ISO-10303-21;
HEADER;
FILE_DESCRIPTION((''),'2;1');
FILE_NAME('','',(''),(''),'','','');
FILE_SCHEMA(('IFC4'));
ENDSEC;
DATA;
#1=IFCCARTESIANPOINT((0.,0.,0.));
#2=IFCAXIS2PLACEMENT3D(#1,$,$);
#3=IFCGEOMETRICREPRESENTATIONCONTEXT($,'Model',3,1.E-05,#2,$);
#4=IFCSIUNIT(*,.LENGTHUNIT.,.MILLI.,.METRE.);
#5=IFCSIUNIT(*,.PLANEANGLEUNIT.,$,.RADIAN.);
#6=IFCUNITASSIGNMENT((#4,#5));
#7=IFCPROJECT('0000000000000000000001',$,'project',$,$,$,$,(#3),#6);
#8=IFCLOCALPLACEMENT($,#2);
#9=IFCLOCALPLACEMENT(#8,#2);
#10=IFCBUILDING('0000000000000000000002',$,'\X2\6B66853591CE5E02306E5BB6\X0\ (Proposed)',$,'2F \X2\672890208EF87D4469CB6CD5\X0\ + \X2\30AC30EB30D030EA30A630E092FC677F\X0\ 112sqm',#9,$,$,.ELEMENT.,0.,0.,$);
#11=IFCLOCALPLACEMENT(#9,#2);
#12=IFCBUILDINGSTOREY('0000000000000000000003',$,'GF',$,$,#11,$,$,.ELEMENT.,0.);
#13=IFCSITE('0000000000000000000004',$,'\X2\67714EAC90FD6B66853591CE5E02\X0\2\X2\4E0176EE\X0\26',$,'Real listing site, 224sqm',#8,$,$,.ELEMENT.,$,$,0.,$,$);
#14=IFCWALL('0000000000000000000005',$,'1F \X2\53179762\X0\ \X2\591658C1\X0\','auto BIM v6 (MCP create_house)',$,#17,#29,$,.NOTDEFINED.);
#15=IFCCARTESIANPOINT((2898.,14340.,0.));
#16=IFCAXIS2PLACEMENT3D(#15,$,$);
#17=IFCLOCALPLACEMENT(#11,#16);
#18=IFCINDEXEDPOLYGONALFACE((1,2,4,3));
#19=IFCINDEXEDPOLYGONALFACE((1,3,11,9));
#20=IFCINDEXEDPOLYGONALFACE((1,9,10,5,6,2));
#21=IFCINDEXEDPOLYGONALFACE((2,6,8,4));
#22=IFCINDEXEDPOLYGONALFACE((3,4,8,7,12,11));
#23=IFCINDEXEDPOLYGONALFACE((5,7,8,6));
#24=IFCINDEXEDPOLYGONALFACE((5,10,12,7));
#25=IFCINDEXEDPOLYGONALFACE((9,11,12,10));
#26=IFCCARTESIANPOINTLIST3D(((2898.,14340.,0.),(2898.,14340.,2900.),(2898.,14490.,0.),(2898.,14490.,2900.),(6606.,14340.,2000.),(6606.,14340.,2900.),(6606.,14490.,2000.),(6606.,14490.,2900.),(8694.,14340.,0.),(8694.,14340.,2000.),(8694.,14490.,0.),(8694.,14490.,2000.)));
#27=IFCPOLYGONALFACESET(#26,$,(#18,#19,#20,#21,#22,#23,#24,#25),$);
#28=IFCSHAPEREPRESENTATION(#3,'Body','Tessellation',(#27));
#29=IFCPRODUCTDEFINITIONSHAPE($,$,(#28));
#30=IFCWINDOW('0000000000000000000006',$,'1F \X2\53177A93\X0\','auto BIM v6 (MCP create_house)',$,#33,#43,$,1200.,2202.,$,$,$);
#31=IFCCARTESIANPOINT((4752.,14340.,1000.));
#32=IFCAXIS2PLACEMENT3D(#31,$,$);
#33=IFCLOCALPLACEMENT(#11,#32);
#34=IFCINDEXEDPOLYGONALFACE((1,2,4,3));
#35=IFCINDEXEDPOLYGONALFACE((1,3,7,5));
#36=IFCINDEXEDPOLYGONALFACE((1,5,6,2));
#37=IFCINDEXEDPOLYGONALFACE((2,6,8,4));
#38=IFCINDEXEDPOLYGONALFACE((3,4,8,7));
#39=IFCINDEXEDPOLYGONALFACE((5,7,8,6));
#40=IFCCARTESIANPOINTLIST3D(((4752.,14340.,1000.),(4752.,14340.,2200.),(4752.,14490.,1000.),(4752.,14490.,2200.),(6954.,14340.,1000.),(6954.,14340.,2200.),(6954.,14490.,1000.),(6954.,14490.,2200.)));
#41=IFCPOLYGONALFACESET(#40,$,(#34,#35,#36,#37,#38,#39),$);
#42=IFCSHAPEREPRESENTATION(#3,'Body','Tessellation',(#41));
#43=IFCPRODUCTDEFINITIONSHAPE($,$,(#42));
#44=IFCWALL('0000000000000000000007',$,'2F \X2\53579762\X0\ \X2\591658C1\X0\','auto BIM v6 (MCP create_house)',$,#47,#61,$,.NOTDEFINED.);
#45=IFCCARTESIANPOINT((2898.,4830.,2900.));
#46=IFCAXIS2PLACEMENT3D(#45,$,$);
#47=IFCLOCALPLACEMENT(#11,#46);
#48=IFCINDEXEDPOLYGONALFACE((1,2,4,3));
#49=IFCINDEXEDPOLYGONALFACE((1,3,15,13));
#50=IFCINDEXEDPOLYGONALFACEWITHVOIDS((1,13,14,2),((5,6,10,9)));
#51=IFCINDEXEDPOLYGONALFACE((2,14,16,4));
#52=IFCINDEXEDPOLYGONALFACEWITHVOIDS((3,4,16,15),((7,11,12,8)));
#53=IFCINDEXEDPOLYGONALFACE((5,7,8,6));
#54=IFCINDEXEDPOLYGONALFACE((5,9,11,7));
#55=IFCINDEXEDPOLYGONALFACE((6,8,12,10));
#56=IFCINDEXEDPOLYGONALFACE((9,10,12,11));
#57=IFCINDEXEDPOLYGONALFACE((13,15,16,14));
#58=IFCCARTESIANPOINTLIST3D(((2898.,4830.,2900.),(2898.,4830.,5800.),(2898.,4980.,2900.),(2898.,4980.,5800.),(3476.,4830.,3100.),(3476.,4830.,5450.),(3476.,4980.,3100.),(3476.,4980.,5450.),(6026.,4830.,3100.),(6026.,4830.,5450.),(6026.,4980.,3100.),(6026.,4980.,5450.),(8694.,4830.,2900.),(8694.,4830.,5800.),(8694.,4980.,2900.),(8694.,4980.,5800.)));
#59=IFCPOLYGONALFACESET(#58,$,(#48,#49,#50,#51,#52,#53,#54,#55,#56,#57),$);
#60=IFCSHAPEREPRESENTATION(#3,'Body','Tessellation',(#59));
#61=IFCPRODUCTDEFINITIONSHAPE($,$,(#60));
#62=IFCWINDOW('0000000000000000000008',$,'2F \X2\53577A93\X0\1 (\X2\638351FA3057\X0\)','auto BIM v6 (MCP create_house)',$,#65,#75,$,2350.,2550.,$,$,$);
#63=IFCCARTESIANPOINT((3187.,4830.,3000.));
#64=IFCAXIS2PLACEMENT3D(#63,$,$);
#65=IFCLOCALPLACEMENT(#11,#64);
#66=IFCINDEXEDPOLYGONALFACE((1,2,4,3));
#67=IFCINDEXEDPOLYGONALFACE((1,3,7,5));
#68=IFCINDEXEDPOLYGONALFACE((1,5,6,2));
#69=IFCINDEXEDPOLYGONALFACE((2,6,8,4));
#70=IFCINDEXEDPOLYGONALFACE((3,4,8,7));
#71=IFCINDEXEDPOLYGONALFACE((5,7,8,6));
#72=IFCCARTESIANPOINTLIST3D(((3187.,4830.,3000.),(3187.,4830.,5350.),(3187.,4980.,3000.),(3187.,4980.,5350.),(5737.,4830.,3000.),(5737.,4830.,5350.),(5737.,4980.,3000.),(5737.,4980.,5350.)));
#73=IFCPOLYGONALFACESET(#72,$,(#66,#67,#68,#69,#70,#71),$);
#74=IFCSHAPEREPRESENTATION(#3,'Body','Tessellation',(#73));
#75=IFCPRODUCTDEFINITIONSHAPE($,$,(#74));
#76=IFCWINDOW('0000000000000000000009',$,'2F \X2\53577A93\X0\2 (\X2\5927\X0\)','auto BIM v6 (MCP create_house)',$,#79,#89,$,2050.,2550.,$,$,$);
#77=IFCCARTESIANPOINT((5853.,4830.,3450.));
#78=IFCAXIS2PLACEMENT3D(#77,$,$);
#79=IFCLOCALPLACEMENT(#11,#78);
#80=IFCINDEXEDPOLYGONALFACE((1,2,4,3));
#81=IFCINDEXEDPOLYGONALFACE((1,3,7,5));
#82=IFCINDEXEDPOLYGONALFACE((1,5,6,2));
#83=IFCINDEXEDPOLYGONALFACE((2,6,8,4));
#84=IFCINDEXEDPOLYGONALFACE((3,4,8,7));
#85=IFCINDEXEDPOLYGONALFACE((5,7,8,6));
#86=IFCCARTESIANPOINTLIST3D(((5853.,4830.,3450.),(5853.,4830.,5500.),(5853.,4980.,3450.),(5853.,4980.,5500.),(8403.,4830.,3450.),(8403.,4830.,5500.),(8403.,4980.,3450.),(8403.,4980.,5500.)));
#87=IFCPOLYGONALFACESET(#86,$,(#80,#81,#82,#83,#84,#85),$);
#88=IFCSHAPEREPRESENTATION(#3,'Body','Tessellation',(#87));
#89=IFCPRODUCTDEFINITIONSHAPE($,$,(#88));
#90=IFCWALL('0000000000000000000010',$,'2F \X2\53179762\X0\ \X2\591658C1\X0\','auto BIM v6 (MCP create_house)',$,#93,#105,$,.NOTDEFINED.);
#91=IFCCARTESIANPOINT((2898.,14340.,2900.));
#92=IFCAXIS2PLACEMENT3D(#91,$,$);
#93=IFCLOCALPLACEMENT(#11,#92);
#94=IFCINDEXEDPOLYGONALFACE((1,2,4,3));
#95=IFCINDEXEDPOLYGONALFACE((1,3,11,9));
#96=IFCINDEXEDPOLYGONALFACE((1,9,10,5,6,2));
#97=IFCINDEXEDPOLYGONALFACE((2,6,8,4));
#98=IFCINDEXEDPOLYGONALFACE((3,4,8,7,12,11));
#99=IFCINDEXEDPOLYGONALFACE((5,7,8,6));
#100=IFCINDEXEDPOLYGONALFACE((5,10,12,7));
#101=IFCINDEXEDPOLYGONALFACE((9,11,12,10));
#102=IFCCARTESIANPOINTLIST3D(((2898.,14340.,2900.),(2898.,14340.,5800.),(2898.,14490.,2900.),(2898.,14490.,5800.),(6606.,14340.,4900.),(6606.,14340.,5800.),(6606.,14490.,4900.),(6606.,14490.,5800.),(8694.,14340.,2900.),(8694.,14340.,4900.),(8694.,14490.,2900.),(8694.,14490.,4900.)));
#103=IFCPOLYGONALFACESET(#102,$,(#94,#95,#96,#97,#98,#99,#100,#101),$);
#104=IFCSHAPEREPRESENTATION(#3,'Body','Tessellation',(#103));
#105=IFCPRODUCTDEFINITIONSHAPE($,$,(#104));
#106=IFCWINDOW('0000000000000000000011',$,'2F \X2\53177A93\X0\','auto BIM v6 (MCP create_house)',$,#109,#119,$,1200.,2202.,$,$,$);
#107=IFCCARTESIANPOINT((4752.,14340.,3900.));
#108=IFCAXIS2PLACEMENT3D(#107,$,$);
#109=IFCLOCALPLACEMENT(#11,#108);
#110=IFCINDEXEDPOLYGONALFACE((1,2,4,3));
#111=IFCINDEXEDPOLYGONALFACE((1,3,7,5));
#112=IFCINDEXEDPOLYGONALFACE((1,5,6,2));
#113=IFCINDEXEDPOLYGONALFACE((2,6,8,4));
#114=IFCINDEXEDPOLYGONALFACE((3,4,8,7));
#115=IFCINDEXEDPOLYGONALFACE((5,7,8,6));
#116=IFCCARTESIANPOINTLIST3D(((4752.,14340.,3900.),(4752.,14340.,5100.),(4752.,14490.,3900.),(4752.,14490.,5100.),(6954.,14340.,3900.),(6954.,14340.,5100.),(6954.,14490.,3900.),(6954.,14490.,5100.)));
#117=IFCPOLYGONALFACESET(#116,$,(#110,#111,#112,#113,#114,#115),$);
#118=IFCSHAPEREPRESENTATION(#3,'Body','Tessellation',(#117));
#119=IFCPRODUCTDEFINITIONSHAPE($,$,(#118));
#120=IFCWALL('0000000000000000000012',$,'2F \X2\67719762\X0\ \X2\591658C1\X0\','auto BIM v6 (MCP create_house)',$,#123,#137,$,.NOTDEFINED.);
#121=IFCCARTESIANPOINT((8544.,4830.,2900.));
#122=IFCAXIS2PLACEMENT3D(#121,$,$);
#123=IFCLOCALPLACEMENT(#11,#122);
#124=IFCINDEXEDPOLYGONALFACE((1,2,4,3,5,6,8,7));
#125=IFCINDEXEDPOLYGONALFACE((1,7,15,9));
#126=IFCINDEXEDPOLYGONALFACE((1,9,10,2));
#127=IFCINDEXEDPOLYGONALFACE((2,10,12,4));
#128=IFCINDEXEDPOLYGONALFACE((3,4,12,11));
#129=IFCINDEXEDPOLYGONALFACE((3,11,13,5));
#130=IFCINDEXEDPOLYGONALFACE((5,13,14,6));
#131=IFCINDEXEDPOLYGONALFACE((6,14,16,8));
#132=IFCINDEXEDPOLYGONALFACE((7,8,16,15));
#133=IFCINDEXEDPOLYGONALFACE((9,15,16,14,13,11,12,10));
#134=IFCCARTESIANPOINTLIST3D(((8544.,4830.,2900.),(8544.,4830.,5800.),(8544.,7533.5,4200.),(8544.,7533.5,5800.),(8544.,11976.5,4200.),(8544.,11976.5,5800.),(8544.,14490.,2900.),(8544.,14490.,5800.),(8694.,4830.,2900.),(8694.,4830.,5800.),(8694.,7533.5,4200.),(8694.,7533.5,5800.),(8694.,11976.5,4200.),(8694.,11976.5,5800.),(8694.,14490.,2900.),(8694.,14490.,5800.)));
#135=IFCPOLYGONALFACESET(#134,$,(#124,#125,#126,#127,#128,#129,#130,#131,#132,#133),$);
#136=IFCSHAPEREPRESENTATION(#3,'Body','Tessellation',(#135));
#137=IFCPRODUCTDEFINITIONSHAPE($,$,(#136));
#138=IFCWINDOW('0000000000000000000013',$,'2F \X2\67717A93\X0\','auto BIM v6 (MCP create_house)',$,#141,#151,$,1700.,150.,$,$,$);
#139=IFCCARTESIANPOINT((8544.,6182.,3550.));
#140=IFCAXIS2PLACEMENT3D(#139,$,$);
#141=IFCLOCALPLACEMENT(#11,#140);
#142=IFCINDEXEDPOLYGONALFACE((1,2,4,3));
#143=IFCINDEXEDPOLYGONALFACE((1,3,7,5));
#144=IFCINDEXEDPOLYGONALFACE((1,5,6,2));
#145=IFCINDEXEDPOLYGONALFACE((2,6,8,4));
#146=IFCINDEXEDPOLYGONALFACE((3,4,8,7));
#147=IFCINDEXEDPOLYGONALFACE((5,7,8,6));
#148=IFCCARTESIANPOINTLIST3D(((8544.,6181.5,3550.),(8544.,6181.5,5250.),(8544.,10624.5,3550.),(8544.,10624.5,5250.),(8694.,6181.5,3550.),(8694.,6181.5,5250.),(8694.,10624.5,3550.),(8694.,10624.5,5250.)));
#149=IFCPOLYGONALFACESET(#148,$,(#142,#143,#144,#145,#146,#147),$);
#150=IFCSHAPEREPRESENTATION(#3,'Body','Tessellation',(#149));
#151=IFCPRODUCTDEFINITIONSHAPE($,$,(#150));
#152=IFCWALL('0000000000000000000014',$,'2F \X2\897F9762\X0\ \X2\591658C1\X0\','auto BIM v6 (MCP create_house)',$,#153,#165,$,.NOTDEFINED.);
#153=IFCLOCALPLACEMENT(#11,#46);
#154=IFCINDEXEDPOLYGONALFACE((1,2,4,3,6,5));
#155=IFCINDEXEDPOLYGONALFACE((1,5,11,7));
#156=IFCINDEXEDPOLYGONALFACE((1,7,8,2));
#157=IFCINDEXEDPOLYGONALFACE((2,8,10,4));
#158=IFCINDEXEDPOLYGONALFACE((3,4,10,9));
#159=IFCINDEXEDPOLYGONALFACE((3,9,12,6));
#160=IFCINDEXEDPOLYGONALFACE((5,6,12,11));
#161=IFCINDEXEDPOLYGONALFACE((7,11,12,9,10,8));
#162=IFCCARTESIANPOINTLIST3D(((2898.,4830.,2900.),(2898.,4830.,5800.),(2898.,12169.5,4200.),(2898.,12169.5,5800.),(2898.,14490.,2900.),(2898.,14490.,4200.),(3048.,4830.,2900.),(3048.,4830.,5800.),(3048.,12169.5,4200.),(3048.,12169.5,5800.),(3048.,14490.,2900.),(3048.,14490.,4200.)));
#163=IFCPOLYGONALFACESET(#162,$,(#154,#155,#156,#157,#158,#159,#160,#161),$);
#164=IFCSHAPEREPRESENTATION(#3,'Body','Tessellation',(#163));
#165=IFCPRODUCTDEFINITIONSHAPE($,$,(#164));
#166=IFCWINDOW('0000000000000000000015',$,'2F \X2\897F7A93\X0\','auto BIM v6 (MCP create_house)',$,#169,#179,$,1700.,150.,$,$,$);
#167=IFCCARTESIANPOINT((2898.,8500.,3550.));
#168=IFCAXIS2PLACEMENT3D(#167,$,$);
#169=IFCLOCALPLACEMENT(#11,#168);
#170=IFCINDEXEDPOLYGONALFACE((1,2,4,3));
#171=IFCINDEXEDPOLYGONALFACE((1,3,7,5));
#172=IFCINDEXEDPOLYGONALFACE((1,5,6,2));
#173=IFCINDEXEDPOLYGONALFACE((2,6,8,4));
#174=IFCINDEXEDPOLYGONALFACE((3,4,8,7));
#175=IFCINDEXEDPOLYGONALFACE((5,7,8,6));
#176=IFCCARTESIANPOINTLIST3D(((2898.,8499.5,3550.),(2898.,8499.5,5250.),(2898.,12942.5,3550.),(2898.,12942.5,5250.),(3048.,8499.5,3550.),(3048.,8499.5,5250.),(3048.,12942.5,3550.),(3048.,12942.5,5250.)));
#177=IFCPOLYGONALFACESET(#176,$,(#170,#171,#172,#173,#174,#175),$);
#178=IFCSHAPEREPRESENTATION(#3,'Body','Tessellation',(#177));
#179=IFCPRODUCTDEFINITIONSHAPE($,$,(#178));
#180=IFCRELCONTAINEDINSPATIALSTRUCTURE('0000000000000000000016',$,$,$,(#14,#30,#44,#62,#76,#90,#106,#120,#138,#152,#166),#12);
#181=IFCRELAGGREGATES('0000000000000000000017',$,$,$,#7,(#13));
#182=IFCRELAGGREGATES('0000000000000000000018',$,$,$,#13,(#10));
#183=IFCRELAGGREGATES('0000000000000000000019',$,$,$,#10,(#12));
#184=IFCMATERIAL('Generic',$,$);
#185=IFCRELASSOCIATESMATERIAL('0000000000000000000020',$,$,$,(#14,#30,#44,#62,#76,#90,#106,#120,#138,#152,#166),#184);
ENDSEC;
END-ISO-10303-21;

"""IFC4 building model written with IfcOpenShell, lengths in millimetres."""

from ifc_helpers import new_model, si_unit, frame, frame_2d, origin, place, context, project, spatial, rectangle, extrude, material, element, fill, save


model = new_model("IFC4")

# Units and contexts
model_context = context("Model", 3, precision=1e-05, world=origin())
ifc_project = project(units=[si_unit("LENGTHUNIT", "METRE", prefix="MILLI"), si_unit("PLANEANGLEUNIT", "RADIAN")], contexts=[model_context])

# Site, building, storey
site_placement = place(None, origin())
site = spatial("IfcSite", under=ifc_project, at=site_placement, Name="東京都武蔵野市2丁目26", ObjectType="Real listing site, 224sqm", CompositionType="ELEMENT", RefElevation=0.0)
building_placement = place(site_placement, origin())
building = spatial("IfcBuilding", under=site, at=building_placement, Name="武蔵野市の家 (Proposed)", ObjectType="2F 木造軸組構法 + ガルバリウム鋼板 112sqm", CompositionType="ELEMENT", ElevationOfRefHeight=0.0, ElevationOfTerrain=0.0)
storey_placement = place(building_placement, origin())
storey = spatial("IfcBuildingStorey", under=building, at=storey_placement, Name="GF", CompositionType="ELEMENT", Elevation=0.0)

# Wall, opening, window
ifc_material = material(Name="Generic")
wall_1_placement = place(storey_placement, frame((2898.0, 14340.0, 0.0)))
wall_1 = element("IfcWall", 1, at=wall_1_placement, inside=storey, material=ifc_material, Name="1F 北面 外壁", Description="auto BIM v6 (MCP create_house)", PredefinedType="NOTDEFINED", context=model_context, shape_type="SweptSolid", body=[
    extrude(rectangle(XDim=5796.0, YDim=150.0, at=frame_2d((2898.0, 75.0))), frame((2898.0, 14340.0, 0.0)), (0.0, 0.0, 1.0), 2900.0),
])
opening_1_placement = place(storey_placement, frame((4752.0, 14340.0, 1000.0)))
opening_1 = element("IfcOpeningElement", 2, at=opening_1_placement, cuts=wall_1, PredefinedType="NOTDEFINED", context=model_context, shape_type="SweptSolid", body=[
    extrude(rectangle(XDim=2202.0, YDim=150.0, at=frame_2d((1101.0, 75.0))), frame((4752.0, 14340.0, 1000.0)), (0.0, 0.0, 1.0), 1200.0),
])
window_1_placement = place(storey_placement, frame((4752.0, 14340.0, 1000.0)))
window_1 = element("IfcWindow", 3, at=window_1_placement, inside=storey, material=ifc_material, Name="1F 北窓", Description="auto BIM v6 (MCP create_house)", OverallHeight=1200.0, OverallWidth=2202.0, context=model_context, shape_type="SweptSolid", body=[
    extrude(rectangle(XDim=2202.0, YDim=150.0, at=frame_2d((1101.0, 75.0))), frame((4752.0, 14340.0, 1000.0)), (0.0, 0.0, 1.0), 1200.0),
])
fill(opening_1, window_1)

# Wall, openings, windows
wall_2_placement = place(storey_placement, frame((2898.0, 4830.0, 2900.0)))
wall_2 = element("IfcWall", 4, at=wall_2_placement, inside=storey, material=ifc_material, Name="2F 南面 外壁", Description="auto BIM v6 (MCP create_house)", PredefinedType="NOTDEFINED", context=model_context, shape_type="SweptSolid", body=[
    extrude(rectangle(XDim=5796.0, YDim=150.0, at=frame_2d((2898.0, 75.0))), frame((2898.0, 4830.0, 2900.0)), (0.0, 0.0, 1.0), 2900.0),
])
opening_2_placement = place(storey_placement, frame((3187.0, 4830.0, 3000.0)))
opening_2 = element("IfcOpeningElement", 5, at=opening_2_placement, cuts=wall_2, PredefinedType="NOTDEFINED", context=model_context, shape_type="SweptSolid", body=[
    extrude(rectangle(XDim=2550.0, YDim=150.0, at=frame_2d((1275.0, 75.0))), frame((3187.0, 4830.0, 3000.0)), (0.0, 0.0, 1.0), 2350.0),
])
opening_3_placement = place(storey_placement, frame((5853.0, 4830.0, 3450.0)))
opening_3 = element("IfcOpeningElement", 6, at=opening_3_placement, cuts=wall_2, PredefinedType="NOTDEFINED", context=model_context, shape_type="SweptSolid", body=[
    extrude(rectangle(XDim=2550.0, YDim=150.0, at=frame_2d((1275.0, 75.0))), frame((5853.0, 4830.0, 3450.0)), (0.0, 0.0, 1.0), 2050.0),
])
window_2_placement = place(storey_placement, frame((3187.0, 4830.0, 3000.0)))
window_2 = element("IfcWindow", 7, at=window_2_placement, inside=storey, material=ifc_material, Name="2F 南窓1 (掃出し)", Description="auto BIM v6 (MCP create_house)", OverallHeight=2350.0, OverallWidth=2550.0, context=model_context, shape_type="SweptSolid", body=[
    extrude(rectangle(XDim=2550.0, YDim=150.0, at=frame_2d((1275.0, 75.0))), frame((3187.0, 4830.0, 3000.0)), (0.0, 0.0, 1.0), 2350.0),
])
fill(opening_2, window_2)
window_3_placement = place(storey_placement, frame((5853.0, 4830.0, 3450.0)))
window_3 = element("IfcWindow", 8, at=window_3_placement, inside=storey, material=ifc_material, Name="2F 南窓2 (大)", Description="auto BIM v6 (MCP create_house)", OverallHeight=2050.0, OverallWidth=2550.0, context=model_context, shape_type="SweptSolid", body=[
    extrude(rectangle(XDim=2550.0, YDim=150.0, at=frame_2d((1275.0, 75.0))), frame((5853.0, 4830.0, 3450.0)), (0.0, 0.0, 1.0), 2050.0),
])
fill(opening_3, window_3)

# Walls, openings, windows
wall_3_placement = place(storey_placement, frame((2898.0, 14340.0, 2900.0)))
wall_3 = element("IfcWall", 9, at=wall_3_placement, inside=storey, material=ifc_material, Name="2F 北面 外壁", Description="auto BIM v6 (MCP create_house)", PredefinedType="NOTDEFINED", context=model_context, shape_type="SweptSolid", body=[
    extrude(rectangle(XDim=5796.0, YDim=150.0, at=frame_2d((2898.0, 75.0))), frame((2898.0, 14340.0, 2900.0)), (0.0, 0.0, 1.0), 2900.0),
])
opening_4_placement = place(storey_placement, frame((4752.0, 14340.0, 3900.0)))
opening_4 = element("IfcOpeningElement", 10, at=opening_4_placement, cuts=wall_3, PredefinedType="NOTDEFINED", context=model_context, shape_type="SweptSolid", body=[
    extrude(rectangle(XDim=2202.0, YDim=150.0, at=frame_2d((1101.0, 75.0))), frame((4752.0, 14340.0, 3900.0)), (0.0, 0.0, 1.0), 1200.0),
])
window_4_placement = place(storey_placement, frame((4752.0, 14340.0, 3900.0)))
window_4 = element("IfcWindow", 11, at=window_4_placement, inside=storey, material=ifc_material, Name="2F 北窓", Description="auto BIM v6 (MCP create_house)", OverallHeight=1200.0, OverallWidth=2202.0, context=model_context, shape_type="SweptSolid", body=[
    extrude(rectangle(XDim=2202.0, YDim=150.0, at=frame_2d((1101.0, 75.0))), frame((4752.0, 14340.0, 3900.0)), (0.0, 0.0, 1.0), 1200.0),
])
fill(opening_4, window_4)
wall_4_placement = place(storey_placement, frame((8544.0, 4830.0, 2900.0)))
wall_4 = element("IfcWall", 12, at=wall_4_placement, inside=storey, material=ifc_material, Name="2F 東面 外壁", Description="auto BIM v6 (MCP create_house)", PredefinedType="NOTDEFINED", context=model_context, shape_type="SweptSolid", body=[
    extrude(rectangle(XDim=150.0, YDim=9660.0, at=frame_2d((75.0, 4830.0))), frame((8544.0, 4830.0, 2900.0)), (0.0, 0.0, 1.0), 2900.0),
])
opening_5_placement = place(storey_placement, frame((8544.0, 6182.0, 3550.0)))
opening_5 = element("IfcOpeningElement", 13, at=opening_5_placement, cuts=wall_4, PredefinedType="NOTDEFINED", context=model_context, shape_type="SweptSolid", body=[
    extrude(rectangle(XDim=150.0, YDim=4443.0, at=frame_2d((75.0, 2221.0))), frame((8544.0, 6182.0, 3550.0)), (0.0, 0.0, 1.0), 1700.0),
])
window_5_placement = place(storey_placement, frame((8544.0, 6182.0, 3550.0)))
window_5 = element("IfcWindow", 14, at=window_5_placement, inside=storey, material=ifc_material, Name="2F 東窓", Description="auto BIM v6 (MCP create_house)", OverallHeight=1700.0, OverallWidth=150.0, context=model_context, shape_type="SweptSolid", body=[
    extrude(rectangle(XDim=150.0, YDim=4443.0, at=frame_2d((75.0, 2221.0))), frame((8544.0, 6182.0, 3550.0)), (0.0, 0.0, 1.0), 1700.0),
])
fill(opening_5, window_5)
wall_5_placement = place(storey_placement, frame((2898.0, 4830.0, 2900.0)))
wall_5 = element("IfcWall", 15, at=wall_5_placement, inside=storey, material=ifc_material, Name="2F 西面 外壁", Description="auto BIM v6 (MCP create_house)", PredefinedType="NOTDEFINED", context=model_context, shape_type="SweptSolid", body=[
    extrude(rectangle(XDim=150.0, YDim=9660.0, at=frame_2d((75.0, 4830.0))), frame((2898.0, 4830.0, 2900.0)), (0.0, 0.0, 1.0), 2900.0),
])
opening_6_placement = place(storey_placement, frame((2898.0, 8500.0, 3550.0)))
opening_6 = element("IfcOpeningElement", 16, at=opening_6_placement, cuts=wall_5, PredefinedType="NOTDEFINED", context=model_context, shape_type="SweptSolid", body=[
    extrude(rectangle(XDim=150.0, YDim=4443.0, at=frame_2d((75.0, 2221.0))), frame((2898.0, 8500.0, 3550.0)), (0.0, 0.0, 1.0), 1700.0),
])
window_6_placement = place(storey_placement, frame((2898.0, 8500.0, 3550.0)))
window_6 = element("IfcWindow", 17, at=window_6_placement, inside=storey, material=ifc_material, Name="2F 西窓", Description="auto BIM v6 (MCP create_house)", OverallHeight=1700.0, OverallWidth=150.0, context=model_context, shape_type="SweptSolid", body=[
    extrude(rectangle(XDim=150.0, YDim=4443.0, at=frame_2d((75.0, 2221.0))), frame((2898.0, 8500.0, 3550.0)), (0.0, 0.0, 1.0), 1700.0),
])
fill(opening_6, window_6)

save(model, "model.ifc")
